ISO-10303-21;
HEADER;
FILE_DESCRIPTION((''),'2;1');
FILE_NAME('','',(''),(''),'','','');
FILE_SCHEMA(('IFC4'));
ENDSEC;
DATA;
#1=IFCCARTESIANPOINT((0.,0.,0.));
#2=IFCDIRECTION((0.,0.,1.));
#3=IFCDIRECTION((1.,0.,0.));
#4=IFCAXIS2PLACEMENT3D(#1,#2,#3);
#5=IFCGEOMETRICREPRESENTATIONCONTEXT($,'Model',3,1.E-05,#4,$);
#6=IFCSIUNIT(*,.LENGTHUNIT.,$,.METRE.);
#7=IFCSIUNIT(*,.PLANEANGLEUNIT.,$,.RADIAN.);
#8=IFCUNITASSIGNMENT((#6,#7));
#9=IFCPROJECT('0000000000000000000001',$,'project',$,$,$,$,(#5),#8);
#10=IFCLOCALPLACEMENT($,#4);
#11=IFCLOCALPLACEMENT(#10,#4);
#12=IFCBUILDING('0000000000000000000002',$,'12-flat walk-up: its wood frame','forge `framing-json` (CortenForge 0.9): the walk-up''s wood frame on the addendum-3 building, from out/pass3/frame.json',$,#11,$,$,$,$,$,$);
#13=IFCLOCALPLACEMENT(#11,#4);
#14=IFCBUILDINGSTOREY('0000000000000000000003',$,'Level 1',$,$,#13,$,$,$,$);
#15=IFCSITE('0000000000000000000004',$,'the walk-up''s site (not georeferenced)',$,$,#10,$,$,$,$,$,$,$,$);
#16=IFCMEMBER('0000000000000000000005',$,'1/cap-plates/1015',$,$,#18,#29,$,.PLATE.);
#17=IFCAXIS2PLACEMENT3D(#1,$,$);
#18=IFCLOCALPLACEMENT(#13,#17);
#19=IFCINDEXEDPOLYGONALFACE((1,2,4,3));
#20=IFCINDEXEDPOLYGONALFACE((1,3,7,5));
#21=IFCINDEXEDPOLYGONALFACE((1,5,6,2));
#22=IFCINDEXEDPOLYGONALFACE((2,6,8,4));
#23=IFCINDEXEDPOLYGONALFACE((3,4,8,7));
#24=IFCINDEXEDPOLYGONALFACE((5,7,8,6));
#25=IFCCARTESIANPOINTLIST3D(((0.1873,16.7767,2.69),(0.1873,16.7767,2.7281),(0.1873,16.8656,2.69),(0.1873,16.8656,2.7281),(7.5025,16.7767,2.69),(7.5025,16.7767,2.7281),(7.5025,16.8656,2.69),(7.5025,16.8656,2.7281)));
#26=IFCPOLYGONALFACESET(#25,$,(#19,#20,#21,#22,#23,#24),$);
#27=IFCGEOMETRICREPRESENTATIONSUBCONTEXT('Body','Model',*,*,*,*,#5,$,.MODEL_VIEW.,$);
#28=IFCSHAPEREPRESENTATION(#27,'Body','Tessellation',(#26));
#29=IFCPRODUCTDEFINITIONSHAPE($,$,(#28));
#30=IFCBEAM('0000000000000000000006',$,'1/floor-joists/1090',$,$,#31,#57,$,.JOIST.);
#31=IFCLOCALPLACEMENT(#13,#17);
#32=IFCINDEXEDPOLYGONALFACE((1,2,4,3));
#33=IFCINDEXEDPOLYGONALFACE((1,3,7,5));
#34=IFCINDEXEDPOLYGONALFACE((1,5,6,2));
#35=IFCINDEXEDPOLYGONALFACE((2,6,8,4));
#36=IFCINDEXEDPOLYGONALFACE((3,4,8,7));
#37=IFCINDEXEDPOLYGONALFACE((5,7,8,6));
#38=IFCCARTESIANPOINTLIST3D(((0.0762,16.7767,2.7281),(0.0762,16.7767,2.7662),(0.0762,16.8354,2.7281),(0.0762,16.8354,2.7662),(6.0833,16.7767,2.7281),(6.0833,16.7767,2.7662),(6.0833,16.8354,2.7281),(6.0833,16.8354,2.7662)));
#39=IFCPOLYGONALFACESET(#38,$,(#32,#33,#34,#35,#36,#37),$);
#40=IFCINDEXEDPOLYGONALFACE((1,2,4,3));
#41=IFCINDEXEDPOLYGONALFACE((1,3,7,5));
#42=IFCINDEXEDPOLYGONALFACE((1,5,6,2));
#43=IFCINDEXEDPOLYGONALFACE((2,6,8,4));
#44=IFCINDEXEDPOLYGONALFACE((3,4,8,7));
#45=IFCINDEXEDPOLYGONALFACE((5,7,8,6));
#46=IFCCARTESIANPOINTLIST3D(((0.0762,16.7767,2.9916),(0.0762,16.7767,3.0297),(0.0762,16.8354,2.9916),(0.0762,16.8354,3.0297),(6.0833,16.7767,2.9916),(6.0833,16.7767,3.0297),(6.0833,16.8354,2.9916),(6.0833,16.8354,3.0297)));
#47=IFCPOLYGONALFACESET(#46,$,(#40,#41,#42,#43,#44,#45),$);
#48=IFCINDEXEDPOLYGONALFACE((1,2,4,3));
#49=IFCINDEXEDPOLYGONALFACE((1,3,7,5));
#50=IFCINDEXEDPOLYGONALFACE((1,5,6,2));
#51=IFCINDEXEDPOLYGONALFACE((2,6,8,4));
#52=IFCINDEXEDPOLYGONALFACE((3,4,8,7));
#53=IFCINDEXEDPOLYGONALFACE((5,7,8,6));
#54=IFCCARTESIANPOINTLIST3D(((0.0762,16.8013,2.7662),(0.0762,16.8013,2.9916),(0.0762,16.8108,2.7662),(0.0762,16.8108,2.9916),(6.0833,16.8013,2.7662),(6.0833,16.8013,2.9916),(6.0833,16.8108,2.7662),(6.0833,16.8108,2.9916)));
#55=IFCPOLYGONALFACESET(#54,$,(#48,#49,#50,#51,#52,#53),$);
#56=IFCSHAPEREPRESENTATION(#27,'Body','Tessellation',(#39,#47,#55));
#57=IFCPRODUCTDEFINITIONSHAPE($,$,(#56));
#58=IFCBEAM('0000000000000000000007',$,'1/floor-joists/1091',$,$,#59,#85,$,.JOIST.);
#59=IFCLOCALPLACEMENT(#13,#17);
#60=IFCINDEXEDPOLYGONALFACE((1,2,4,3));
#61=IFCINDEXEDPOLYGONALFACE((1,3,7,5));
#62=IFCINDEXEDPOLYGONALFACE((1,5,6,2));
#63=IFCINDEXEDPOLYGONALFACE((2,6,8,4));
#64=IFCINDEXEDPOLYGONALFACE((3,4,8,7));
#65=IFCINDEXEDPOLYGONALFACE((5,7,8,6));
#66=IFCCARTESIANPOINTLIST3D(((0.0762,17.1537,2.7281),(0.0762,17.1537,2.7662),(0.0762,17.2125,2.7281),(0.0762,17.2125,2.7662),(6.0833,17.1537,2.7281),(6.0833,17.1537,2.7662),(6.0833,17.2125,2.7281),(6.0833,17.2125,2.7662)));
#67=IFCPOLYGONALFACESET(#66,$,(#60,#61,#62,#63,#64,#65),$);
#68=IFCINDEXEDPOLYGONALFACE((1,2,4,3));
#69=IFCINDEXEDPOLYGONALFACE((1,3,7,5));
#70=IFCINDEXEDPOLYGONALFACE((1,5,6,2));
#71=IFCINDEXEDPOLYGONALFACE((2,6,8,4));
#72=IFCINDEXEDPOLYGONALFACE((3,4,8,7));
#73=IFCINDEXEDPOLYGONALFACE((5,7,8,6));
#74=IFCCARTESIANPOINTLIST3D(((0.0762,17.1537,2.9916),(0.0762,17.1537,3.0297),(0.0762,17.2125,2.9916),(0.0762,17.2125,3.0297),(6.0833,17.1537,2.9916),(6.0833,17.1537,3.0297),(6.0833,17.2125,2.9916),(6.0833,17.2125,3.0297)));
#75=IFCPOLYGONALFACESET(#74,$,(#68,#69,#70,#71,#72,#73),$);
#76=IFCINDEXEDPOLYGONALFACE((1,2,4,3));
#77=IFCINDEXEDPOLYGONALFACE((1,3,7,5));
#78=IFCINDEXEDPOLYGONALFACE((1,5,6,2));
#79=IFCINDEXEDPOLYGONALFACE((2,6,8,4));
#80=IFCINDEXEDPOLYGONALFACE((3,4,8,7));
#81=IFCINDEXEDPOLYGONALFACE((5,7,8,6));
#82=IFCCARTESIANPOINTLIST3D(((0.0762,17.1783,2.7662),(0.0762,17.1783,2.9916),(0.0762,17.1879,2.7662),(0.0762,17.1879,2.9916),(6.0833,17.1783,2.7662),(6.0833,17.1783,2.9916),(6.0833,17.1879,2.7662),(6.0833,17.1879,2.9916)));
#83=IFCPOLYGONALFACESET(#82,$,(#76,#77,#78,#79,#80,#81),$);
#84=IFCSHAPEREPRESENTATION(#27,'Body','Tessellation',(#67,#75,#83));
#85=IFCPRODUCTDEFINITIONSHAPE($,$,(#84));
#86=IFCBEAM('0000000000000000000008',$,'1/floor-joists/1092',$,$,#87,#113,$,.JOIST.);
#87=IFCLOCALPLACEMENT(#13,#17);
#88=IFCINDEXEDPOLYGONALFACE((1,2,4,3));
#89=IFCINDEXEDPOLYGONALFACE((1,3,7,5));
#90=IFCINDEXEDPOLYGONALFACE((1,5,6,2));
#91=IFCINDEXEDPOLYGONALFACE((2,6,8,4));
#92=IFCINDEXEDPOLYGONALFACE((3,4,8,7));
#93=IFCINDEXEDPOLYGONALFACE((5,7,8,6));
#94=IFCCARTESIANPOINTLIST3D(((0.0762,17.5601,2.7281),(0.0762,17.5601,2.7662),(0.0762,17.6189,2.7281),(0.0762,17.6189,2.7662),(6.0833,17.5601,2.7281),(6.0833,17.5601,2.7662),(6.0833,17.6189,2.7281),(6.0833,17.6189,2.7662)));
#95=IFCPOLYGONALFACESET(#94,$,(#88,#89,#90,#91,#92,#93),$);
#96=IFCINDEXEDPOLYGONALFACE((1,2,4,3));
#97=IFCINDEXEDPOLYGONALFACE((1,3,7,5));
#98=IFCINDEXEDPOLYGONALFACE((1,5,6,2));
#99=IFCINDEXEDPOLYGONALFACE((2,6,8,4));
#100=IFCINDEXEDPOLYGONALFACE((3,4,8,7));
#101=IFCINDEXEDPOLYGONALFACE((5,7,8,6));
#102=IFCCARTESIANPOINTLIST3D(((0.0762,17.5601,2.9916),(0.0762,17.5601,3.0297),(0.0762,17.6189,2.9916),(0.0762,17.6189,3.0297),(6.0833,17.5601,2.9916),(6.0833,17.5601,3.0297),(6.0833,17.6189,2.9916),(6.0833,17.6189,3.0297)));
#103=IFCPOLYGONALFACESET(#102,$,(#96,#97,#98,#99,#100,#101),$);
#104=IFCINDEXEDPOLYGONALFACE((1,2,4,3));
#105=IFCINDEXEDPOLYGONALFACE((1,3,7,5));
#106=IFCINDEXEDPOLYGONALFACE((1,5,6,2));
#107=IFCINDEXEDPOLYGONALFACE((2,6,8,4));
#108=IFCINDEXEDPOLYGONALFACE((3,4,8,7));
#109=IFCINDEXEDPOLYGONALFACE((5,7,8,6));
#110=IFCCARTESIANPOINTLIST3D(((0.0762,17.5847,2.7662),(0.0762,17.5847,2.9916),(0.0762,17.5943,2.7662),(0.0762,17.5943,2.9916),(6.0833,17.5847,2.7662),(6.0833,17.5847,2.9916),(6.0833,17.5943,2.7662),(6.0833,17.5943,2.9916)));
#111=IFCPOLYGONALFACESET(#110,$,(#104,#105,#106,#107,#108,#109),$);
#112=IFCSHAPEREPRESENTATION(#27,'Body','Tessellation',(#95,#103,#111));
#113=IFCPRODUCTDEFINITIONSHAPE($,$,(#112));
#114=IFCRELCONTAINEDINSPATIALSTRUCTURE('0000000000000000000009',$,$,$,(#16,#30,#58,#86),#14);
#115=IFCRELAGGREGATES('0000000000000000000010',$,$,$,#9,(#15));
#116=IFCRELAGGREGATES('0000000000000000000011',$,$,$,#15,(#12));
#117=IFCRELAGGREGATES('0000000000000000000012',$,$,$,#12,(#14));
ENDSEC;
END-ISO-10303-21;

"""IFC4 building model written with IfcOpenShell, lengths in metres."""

from ifc_helpers import new_model, si_unit, frame, frame_2d, origin, origin_with_axes, place, context, subcontext, project, spatial, rectangle, extrude, element, save


model = new_model("IFC4")

# Units and contexts
model_context = context("Model", 3, precision=1e-05, world=origin_with_axes())
body_context = subcontext(model_context, "Body", "Model", "MODEL_VIEW")
ifc_project = project(units=[si_unit("LENGTHUNIT", "METRE"), si_unit("PLANEANGLEUNIT", "RADIAN")], contexts=[model_context])

# Site, building, storey
site_placement = place(None, origin_with_axes())
site = spatial("IfcSite", under=ifc_project, at=site_placement, Name="the walk-up's site (not georeferenced)")
building_placement = place(site_placement, origin_with_axes())
building = spatial("IfcBuilding", under=site, at=building_placement, Name="12-flat walk-up: its wood frame", Description="forge `framing-json` (CortenForge 0.9): the walk-up's wood frame on the addendum-3 building, from out/pass3/frame.json")
storey_placement = place(building_placement, origin_with_axes())
storey = spatial("IfcBuildingStorey", under=building, at=storey_placement, Name="Level 1")

# Member
member_1_placement = place(storey_placement, frame((0.1873, 16.7767, 2.69), z_axis=(0.0, 0.0, 1.0), x_axis=(1.0, 0.0, 0.0)))
element("IfcMember", 1, at=member_1_placement, inside=storey, Name="1/cap-plates/1015", PredefinedType="PLATE", context=body_context, shape_type="SweptSolid", body=[
    extrude(rectangle(XDim=7.3152, YDim=0.0889, at=frame_2d((3.6576, 0.0444))), origin(), (0.0, 0.0, 1.0), 0.0381),
])

# Beams
beam_1_placement = place(storey_placement, frame((0.0762, 16.7767, 2.7281), z_axis=(0.0, 0.0, 1.0), x_axis=(1.0, 0.0, 0.0)))
element("IfcBeam", 2, at=beam_1_placement, inside=storey, Name="1/floor-joists/1090", PredefinedType="JOIST", context=body_context, shape_type="SweptSolid", body=[
    extrude(rectangle(XDim=6.0071, YDim=0.0587, at=frame_2d((3.0036, 0.0294))), origin(), (0.0, 0.0, 1.0), 0.0381),
    extrude(rectangle(XDim=6.0071, YDim=0.0587, at=frame_2d((3.0036, 0.0294))), frame((0.0, 0.0, 0.2635)), (0.0, 0.0, 1.0), 0.0381),
    extrude(rectangle(XDim=6.0071, YDim=0.0095, at=frame_2d((3.0036, 0.0048))), frame((0.0, 0.0246, 0.0381)), (0.0, 0.0, 1.0), 0.2254),
])
beam_2_placement = place(storey_placement, frame((0.0762, 17.1537, 2.7281), z_axis=(0.0, 0.0, 1.0), x_axis=(1.0, 0.0, 0.0)))
element("IfcBeam", 3, at=beam_2_placement, inside=storey, Name="1/floor-joists/1091", PredefinedType="JOIST", context=body_context, shape_type="SweptSolid", body=[
    extrude(rectangle(XDim=6.0071, YDim=0.0587, at=frame_2d((3.0036, 0.0294))), origin(), (0.0, 0.0, 1.0), 0.0381),
    extrude(rectangle(XDim=6.0071, YDim=0.0587, at=frame_2d((3.0036, 0.0294))), frame((0.0, 0.0, 0.2635)), (0.0, 0.0, 1.0), 0.0381),
    extrude(rectangle(XDim=6.0071, YDim=0.0095, at=frame_2d((3.0036, 0.0048))), frame((0.0, 0.0246, 0.0381)), (0.0, 0.0, 1.0), 0.2254),
])
beam_3_placement = place(storey_placement, frame((0.0762, 17.5601, 2.7281), z_axis=(0.0, 0.0, 1.0), x_axis=(1.0, 0.0, 0.0)))
element("IfcBeam", 4, at=beam_3_placement, inside=storey, Name="1/floor-joists/1092", PredefinedType="JOIST", context=body_context, shape_type="SweptSolid", body=[
    extrude(rectangle(XDim=6.0071, YDim=0.0587, at=frame_2d((3.0036, 0.0294))), origin(), (0.0, 0.0, 1.0), 0.0381),
    extrude(rectangle(XDim=6.0071, YDim=0.0587, at=frame_2d((3.0036, 0.0294))), frame((0.0, 0.0, 0.2635)), (0.0, 0.0, 1.0), 0.0381),
    extrude(rectangle(XDim=6.0071, YDim=0.0095, at=frame_2d((3.0036, 0.0048))), frame((0.0, 0.0246, 0.0381)), (0.0, 0.0, 1.0), 0.2254),
])

save(model, "model.ifc")
